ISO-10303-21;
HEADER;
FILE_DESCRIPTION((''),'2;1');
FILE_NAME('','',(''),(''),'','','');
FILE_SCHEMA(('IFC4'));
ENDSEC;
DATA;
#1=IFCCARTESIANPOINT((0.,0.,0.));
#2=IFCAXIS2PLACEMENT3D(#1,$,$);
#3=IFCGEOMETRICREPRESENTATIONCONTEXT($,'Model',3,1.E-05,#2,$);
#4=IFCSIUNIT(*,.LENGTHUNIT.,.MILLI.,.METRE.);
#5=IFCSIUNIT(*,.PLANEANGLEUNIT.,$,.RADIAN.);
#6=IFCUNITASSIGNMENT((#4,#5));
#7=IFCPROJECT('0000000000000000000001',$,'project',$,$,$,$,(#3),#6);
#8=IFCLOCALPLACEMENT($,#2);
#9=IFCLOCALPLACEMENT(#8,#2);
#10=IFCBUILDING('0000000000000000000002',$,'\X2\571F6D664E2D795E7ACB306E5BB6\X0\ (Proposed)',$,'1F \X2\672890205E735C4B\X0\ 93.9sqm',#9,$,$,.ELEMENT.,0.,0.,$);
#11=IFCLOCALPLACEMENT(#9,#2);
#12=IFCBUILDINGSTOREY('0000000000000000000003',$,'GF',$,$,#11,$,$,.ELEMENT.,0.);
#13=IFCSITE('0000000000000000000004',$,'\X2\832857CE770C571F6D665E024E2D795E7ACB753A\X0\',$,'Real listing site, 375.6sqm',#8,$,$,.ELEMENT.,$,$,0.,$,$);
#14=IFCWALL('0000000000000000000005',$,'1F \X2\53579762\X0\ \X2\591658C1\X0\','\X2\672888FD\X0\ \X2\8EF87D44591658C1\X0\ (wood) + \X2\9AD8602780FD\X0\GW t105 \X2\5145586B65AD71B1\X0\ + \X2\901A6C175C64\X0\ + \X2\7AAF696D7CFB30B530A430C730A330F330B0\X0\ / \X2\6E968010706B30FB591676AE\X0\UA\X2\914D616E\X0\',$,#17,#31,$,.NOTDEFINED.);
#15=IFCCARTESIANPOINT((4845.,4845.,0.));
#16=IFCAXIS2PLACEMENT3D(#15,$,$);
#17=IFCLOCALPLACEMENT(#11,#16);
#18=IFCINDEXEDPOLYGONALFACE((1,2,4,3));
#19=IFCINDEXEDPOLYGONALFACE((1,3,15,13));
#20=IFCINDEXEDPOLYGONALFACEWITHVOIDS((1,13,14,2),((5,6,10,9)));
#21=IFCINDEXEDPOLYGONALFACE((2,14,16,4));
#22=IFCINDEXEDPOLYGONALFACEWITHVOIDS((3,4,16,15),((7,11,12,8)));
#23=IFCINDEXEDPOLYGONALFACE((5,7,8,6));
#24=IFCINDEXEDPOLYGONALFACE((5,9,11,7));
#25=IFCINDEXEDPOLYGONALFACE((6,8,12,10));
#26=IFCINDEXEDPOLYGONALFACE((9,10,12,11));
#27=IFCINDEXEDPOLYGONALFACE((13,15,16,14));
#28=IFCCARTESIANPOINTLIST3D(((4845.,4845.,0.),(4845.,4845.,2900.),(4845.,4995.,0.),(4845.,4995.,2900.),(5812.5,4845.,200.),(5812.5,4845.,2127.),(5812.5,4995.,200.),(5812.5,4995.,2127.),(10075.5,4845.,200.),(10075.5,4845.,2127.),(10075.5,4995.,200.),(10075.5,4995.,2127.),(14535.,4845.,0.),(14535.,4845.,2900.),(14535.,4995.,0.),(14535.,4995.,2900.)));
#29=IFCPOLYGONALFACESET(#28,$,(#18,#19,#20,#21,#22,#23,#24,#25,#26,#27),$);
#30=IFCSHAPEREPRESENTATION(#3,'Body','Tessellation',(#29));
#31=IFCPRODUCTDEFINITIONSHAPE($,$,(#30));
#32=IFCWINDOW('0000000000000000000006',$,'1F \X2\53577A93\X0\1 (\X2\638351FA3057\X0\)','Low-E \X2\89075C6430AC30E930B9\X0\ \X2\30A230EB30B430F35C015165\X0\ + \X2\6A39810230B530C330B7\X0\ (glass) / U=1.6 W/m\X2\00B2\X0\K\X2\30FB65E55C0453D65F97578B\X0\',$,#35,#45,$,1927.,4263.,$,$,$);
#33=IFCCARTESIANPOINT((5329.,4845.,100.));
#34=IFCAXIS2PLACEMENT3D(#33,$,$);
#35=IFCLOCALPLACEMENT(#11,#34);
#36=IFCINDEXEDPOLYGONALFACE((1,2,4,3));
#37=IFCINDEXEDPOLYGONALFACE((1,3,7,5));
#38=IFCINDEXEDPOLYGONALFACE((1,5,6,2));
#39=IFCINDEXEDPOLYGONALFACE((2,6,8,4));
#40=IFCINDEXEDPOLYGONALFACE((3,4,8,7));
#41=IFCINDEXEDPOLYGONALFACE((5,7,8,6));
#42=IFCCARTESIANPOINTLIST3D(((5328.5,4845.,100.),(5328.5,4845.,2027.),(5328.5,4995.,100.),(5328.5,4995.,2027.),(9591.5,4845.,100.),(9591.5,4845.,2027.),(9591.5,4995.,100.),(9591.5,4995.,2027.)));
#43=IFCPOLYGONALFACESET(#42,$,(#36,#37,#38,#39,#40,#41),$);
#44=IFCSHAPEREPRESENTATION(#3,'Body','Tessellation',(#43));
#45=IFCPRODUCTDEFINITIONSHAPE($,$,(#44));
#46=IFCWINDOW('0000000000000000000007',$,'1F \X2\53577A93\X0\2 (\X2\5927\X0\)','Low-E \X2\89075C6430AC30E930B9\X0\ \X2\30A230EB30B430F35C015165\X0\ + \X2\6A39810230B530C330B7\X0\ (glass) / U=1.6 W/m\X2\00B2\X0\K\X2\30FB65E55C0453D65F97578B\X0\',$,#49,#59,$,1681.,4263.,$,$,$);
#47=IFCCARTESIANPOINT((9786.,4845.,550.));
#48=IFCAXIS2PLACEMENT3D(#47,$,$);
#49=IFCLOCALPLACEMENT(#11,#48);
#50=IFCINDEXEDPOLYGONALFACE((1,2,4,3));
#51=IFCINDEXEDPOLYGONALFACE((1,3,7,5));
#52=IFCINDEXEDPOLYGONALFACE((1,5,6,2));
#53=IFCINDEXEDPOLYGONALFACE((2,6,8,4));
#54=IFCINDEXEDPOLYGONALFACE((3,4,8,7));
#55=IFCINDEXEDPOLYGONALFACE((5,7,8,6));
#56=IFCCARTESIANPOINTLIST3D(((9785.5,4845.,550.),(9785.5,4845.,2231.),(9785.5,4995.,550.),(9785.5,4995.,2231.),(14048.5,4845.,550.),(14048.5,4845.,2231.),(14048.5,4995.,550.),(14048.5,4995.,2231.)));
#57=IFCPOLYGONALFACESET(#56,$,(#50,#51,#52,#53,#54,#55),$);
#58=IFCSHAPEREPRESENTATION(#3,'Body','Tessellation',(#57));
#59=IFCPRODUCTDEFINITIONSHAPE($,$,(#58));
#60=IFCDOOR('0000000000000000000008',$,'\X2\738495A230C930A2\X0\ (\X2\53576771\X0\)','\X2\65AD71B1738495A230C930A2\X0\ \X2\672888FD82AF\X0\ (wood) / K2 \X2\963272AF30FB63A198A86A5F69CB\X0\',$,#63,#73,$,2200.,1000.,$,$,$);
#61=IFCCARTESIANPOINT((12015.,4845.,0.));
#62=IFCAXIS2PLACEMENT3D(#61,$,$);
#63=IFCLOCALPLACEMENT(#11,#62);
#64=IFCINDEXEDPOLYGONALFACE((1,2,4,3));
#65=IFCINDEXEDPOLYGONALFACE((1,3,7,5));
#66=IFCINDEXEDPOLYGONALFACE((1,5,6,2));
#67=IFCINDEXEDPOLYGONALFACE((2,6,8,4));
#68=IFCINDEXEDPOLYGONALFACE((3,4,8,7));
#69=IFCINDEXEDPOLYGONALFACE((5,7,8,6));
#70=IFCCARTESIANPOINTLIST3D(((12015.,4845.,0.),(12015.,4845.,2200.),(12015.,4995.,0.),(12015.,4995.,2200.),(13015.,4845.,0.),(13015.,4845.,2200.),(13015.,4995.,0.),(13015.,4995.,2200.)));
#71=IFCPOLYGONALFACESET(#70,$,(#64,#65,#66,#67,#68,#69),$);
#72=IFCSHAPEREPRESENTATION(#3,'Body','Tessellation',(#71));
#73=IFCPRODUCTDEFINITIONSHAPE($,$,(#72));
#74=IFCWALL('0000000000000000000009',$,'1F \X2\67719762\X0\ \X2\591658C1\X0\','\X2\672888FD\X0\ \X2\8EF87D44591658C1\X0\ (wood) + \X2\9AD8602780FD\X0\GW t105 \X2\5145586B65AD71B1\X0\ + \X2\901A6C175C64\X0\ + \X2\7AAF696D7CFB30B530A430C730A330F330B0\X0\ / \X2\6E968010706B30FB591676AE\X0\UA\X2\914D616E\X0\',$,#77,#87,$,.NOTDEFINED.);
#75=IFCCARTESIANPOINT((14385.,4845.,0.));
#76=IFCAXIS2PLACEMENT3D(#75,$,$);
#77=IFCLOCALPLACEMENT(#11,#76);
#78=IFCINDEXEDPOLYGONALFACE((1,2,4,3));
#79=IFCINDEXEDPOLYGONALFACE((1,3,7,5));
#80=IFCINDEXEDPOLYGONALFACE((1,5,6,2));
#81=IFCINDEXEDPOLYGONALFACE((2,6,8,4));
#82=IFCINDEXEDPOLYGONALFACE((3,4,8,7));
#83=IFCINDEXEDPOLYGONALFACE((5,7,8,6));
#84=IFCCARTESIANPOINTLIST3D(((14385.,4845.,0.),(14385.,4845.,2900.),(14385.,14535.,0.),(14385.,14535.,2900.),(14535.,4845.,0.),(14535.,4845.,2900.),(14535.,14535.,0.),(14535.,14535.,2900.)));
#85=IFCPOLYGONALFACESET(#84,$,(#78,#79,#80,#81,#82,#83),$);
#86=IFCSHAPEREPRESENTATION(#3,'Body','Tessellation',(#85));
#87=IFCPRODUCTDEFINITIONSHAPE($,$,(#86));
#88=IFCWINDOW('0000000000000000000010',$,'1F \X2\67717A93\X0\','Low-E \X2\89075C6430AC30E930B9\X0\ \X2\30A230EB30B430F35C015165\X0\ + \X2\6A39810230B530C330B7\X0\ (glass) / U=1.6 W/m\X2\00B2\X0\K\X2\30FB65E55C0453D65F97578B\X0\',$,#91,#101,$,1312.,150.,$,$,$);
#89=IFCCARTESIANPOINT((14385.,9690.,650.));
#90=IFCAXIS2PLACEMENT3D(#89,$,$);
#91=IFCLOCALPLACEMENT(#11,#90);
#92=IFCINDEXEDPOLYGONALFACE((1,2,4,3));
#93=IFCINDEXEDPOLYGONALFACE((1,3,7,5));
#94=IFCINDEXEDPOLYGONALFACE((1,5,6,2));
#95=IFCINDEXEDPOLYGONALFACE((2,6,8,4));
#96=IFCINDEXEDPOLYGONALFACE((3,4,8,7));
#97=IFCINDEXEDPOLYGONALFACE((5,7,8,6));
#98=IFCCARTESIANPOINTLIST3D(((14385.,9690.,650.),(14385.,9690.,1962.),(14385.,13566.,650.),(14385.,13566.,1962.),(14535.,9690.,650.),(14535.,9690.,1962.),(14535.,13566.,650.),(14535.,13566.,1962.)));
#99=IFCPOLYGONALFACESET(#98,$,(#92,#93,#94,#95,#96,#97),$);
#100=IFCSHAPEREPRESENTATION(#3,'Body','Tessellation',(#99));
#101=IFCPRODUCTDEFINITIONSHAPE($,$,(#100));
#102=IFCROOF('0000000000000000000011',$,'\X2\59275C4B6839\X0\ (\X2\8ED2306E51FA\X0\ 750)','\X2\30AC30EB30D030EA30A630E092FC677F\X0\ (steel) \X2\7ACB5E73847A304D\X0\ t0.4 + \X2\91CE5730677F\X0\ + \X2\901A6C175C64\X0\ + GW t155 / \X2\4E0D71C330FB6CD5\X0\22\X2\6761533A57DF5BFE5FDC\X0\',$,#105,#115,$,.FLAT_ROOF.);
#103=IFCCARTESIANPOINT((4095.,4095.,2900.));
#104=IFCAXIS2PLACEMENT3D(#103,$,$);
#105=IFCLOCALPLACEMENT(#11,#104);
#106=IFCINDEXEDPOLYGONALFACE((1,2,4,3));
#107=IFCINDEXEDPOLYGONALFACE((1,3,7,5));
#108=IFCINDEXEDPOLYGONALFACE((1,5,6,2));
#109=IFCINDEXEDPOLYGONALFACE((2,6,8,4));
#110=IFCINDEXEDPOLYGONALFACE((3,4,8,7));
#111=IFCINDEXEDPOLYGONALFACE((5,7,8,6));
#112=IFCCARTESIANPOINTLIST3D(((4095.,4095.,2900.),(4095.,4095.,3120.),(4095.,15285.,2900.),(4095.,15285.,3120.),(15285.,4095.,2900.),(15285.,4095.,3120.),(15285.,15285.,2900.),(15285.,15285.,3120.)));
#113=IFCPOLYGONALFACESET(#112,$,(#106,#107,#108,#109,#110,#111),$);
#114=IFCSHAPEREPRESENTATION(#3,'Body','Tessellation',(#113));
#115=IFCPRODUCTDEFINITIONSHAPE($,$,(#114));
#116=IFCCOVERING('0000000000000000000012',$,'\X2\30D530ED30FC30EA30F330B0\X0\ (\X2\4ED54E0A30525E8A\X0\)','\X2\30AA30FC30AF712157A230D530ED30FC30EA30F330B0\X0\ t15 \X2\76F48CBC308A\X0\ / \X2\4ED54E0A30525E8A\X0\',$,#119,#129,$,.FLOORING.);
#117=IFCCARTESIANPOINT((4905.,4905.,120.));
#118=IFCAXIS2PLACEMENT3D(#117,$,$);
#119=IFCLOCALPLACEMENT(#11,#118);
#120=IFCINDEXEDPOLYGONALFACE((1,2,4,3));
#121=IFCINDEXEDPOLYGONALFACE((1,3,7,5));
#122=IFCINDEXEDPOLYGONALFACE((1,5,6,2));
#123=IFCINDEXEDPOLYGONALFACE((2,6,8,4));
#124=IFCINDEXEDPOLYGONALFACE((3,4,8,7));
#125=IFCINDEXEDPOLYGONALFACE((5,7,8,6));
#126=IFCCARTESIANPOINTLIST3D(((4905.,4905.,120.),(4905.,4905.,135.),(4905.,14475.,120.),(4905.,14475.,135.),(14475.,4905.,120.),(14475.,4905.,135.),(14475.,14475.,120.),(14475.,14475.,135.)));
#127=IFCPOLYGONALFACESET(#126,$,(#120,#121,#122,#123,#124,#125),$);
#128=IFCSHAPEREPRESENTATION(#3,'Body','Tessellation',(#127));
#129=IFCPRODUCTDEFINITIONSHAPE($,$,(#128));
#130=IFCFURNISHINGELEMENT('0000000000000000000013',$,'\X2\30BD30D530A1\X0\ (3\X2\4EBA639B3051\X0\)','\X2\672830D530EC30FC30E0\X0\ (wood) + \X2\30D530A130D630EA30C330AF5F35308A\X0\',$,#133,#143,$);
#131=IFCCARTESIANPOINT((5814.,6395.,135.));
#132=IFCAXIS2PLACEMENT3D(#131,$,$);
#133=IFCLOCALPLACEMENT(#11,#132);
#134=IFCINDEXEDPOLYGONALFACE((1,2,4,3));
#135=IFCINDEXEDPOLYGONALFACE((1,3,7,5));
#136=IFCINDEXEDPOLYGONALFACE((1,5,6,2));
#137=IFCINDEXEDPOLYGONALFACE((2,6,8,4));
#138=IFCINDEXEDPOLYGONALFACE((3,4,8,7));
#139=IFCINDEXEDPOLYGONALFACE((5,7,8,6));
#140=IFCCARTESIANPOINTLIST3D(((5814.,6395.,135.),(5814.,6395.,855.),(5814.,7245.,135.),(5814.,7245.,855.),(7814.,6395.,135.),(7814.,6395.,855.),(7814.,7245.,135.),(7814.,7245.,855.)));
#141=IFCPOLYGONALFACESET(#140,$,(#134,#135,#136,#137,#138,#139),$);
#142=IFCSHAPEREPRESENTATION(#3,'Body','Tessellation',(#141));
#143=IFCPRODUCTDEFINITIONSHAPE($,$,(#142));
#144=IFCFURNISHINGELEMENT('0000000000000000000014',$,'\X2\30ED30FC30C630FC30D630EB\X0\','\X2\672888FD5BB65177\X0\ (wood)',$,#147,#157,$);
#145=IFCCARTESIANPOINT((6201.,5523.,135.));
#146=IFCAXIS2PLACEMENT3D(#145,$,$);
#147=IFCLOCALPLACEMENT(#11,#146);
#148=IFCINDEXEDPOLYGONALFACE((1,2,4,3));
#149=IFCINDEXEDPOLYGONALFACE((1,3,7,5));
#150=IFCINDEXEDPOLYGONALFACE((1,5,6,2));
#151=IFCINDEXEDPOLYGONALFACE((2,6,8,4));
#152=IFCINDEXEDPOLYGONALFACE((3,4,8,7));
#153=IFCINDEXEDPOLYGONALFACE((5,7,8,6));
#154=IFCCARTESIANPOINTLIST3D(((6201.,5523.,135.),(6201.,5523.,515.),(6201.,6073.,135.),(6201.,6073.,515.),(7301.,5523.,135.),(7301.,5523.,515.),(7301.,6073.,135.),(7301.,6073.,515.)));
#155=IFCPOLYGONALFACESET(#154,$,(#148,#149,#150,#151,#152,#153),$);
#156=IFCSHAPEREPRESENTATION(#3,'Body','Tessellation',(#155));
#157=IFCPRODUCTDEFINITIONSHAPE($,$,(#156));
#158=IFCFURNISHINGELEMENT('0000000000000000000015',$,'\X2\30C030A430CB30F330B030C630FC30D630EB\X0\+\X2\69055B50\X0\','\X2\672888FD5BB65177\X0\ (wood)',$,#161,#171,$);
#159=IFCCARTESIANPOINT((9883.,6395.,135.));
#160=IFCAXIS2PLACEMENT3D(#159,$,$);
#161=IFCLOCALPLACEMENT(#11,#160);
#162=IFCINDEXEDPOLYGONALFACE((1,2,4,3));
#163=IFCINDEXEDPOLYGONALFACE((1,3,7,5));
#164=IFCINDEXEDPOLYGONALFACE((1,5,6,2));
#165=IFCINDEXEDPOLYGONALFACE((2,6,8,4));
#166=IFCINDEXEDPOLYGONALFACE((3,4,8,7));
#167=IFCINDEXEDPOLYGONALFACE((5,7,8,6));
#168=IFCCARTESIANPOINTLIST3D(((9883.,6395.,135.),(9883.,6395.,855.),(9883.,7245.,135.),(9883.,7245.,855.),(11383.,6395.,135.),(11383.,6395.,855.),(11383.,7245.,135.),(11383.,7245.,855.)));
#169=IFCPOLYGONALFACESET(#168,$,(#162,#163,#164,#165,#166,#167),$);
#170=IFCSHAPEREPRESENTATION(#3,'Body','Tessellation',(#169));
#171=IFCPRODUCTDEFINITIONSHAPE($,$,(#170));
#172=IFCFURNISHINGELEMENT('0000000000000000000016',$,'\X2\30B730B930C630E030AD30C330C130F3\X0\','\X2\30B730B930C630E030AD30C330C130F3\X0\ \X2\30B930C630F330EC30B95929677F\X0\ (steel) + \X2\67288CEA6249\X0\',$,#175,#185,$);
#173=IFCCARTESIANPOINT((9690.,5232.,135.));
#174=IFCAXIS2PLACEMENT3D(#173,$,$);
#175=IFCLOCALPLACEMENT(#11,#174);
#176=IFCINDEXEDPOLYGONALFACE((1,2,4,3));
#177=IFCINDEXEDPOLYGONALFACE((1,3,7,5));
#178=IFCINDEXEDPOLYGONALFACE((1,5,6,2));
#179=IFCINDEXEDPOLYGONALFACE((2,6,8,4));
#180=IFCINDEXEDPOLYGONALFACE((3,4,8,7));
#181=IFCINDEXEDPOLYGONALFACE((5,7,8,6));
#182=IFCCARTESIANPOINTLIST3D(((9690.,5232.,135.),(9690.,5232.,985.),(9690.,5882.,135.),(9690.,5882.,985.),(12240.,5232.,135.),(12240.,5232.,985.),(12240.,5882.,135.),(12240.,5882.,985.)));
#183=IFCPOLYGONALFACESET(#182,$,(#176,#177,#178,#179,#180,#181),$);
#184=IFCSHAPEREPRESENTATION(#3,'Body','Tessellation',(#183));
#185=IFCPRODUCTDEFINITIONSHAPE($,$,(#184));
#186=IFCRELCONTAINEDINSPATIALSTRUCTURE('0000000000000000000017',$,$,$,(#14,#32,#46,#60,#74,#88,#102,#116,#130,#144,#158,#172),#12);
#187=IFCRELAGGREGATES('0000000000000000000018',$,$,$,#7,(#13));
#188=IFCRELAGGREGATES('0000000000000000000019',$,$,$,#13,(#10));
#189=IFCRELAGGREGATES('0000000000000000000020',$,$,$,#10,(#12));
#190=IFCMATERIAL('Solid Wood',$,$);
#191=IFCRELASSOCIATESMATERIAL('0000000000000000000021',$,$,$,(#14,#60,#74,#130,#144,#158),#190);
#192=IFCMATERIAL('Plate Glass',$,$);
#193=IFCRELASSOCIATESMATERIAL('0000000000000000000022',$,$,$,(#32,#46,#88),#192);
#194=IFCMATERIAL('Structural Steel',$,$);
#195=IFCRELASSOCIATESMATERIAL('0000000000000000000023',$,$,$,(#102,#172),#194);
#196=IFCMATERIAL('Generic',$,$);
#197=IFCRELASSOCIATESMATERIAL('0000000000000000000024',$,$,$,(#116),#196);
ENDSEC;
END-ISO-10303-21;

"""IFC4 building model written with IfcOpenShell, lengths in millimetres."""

from ifc_helpers import new_model, si_unit, frame, frame_2d, origin, place, context, project, spatial, rectangle, extrude, material, element, fill, save


model = new_model("IFC4")

# Units and contexts
model_context = context("Model", 3, precision=1e-05, world=origin())
ifc_project = project(units=[si_unit("LENGTHUNIT", "METRE", prefix="MILLI"), si_unit("PLANEANGLEUNIT", "RADIAN")], contexts=[model_context])

# Site, building, storey
site_placement = place(None, origin())
site = spatial("IfcSite", under=ifc_project, at=site_placement, Name="茨城県土浦市中神立町", ObjectType="Real listing site, 375.6sqm", CompositionType="ELEMENT", RefElevation=0.0)
building_placement = place(site_placement, origin())
building = spatial("IfcBuilding", under=site, at=building_placement, Name="土浦中神立の家 (Proposed)", ObjectType="1F 木造平屋 93.9sqm", CompositionType="ELEMENT", ElevationOfRefHeight=0.0, ElevationOfTerrain=0.0)
storey_placement = place(building_placement, origin())
storey = spatial("IfcBuildingStorey", under=building, at=storey_placement, Name="GF", CompositionType="ELEMENT", Elevation=0.0)

# Shared definitions
ifc_material_1 = material(Name="Solid Wood")

# Wall, openings, windows, door
wall_1_placement = place(storey_placement, frame((4845.0, 4845.0, 0.0)))
wall_1 = element("IfcWall", 1, at=wall_1_placement, inside=storey, material=ifc_material_1, Name="1F 南面 外壁", Description="木製 軸組外壁 (wood) + 高性能GW t105 充填断熱 + 通気層 + 窯業系サイディング / 準耐火・外皮UA配慮", PredefinedType="NOTDEFINED", context=model_context, shape_type="SweptSolid", body=[
    extrude(rectangle(XDim=9690.0, YDim=150.0, at=frame_2d((4845.0, 75.0))), frame((4845.0, 4845.0, 0.0)), (0.0, 0.0, 1.0), 2900.0),
])
opening_1_placement = place(storey_placement, frame((5329.0, 4845.0, 100.0)))
opening_1 = element("IfcOpeningElement", 2, at=opening_1_placement, cuts=wall_1, PredefinedType="NOTDEFINED", context=model_context, shape_type="SweptSolid", body=[
    extrude(rectangle(XDim=4263.0, YDim=150.0, at=frame_2d((2131.0, 75.0))), frame((5329.0, 4845.0, 100.0)), (0.0, 0.0, 1.0), 1927.0),
])
opening_2_placement = place(storey_placement, frame((9786.0, 4845.0, 550.0)))
opening_2 = element("IfcOpeningElement", 3, at=opening_2_placement, cuts=wall_1, PredefinedType="NOTDEFINED", context=model_context, shape_type="SweptSolid", body=[
    extrude(rectangle(XDim=4263.0, YDim=150.0, at=frame_2d((2131.0, 75.0))), frame((9786.0, 4845.0, 550.0)), (0.0, 0.0, 1.0), 1681.0),
])
opening_3_placement = place(storey_placement, frame((12015.0, 4845.0, 0.0)))
opening_3 = element("IfcOpeningElement", 4, at=opening_3_placement, cuts=wall_1, PredefinedType="NOTDEFINED", context=model_context, shape_type="SweptSolid", body=[
    extrude(rectangle(XDim=1000.0, YDim=150.0, at=frame_2d((500.0, 75.0))), frame((12015.0, 4845.0, 0.0)), (0.0, 0.0, 1.0), 2200.0),
])
ifc_material_2 = material(Name="Plate Glass")
window_1_placement = place(storey_placement, frame((5329.0, 4845.0, 100.0)))
window_1 = element("IfcWindow", 5, at=window_1_placement, inside=storey, material=ifc_material_2, Name="1F 南窓1 (掃出し)", Description="Low-E 複層ガラス アルゴン封入 + 樹脂サッシ (glass) / U=1.6 W/m²K・日射取得型", OverallHeight=1927.0, OverallWidth=4263.0, context=model_context, shape_type="SweptSolid", body=[
    extrude(rectangle(XDim=4263.0, YDim=150.0, at=frame_2d((2131.0, 75.0))), frame((5329.0, 4845.0, 100.0)), (0.0, 0.0, 1.0), 1927.0),
])
fill(opening_1, window_1)
window_2_placement = place(storey_placement, frame((9786.0, 4845.0, 550.0)))
window_2 = element("IfcWindow", 6, at=window_2_placement, inside=storey, material=ifc_material_2, Name="1F 南窓2 (大)", Description="Low-E 複層ガラス アルゴン封入 + 樹脂サッシ (glass) / U=1.6 W/m²K・日射取得型", OverallHeight=1681.0, OverallWidth=4263.0, context=model_context, shape_type="SweptSolid", body=[
    extrude(rectangle(XDim=4263.0, YDim=150.0, at=frame_2d((2131.0, 75.0))), frame((9786.0, 4845.0, 550.0)), (0.0, 0.0, 1.0), 1681.0),
])
fill(opening_2, window_2)
door_placement = place(storey_placement, frame((12015.0, 4845.0, 0.0)))
door = element("IfcDoor", 7, at=door_placement, inside=storey, material=ifc_material_1, Name="玄関ドア (南東)", Description="断熱玄関ドア 木製芯 (wood) / K2 防犯・採風機構", OverallHeight=2200.0, OverallWidth=1000.0, context=model_context, shape_type="SweptSolid", body=[
    extrude(rectangle(XDim=1000.0, YDim=150.0, at=frame_2d((500.0, 75.0))), frame((12015.0, 4845.0, 0.0)), (0.0, 0.0, 1.0), 2200.0),
])
fill(opening_3, door)

# Wall, opening, window
wall_2_placement = place(storey_placement, frame((14385.0, 4845.0, 0.0)))
wall_2 = element("IfcWall", 8, at=wall_2_placement, inside=storey, material=ifc_material_1, Name="1F 東面 外壁", Description="木製 軸組外壁 (wood) + 高性能GW t105 充填断熱 + 通気層 + 窯業系サイディング / 準耐火・外皮UA配慮", PredefinedType="NOTDEFINED", context=model_context, shape_type="SweptSolid", body=[
    extrude(rectangle(XDim=150.0, YDim=9690.0, at=frame_2d((75.0, 4845.0))), frame((14385.0, 4845.0, 0.0)), (0.0, 0.0, 1.0), 2900.0),
])
opening_4_placement = place(storey_placement, frame((14385.0, 9690.0, 650.0)))
opening_4 = element("IfcOpeningElement", 9, at=opening_4_placement, cuts=wall_2, PredefinedType="NOTDEFINED", context=model_context, shape_type="SweptSolid", body=[
    extrude(rectangle(XDim=150.0, YDim=3876.0, at=frame_2d((75.0, 1938.0))), frame((14385.0, 9690.0, 650.0)), (0.0, 0.0, 1.0), 1312.0),
])
window_3_placement = place(storey_placement, frame((14385.0, 9690.0, 650.0)))
window_3 = element("IfcWindow", 10, at=window_3_placement, inside=storey, material=ifc_material_2, Name="1F 東窓", Description="Low-E 複層ガラス アルゴン封入 + 樹脂サッシ (glass) / U=1.6 W/m²K・日射取得型", OverallHeight=1312.0, OverallWidth=150.0, context=model_context, shape_type="SweptSolid", body=[
    extrude(rectangle(XDim=150.0, YDim=3876.0, at=frame_2d((75.0, 1938.0))), frame((14385.0, 9690.0, 650.0)), (0.0, 0.0, 1.0), 1312.0),
])
fill(opening_4, window_3)

# Roof
ifc_material_3 = material(Name="Structural Steel")
roof_placement = place(storey_placement, frame((4095.0, 4095.0, 2900.0)))
element("IfcRoof", 11, at=roof_placement, inside=storey, material=ifc_material_3, Name="大屋根 (軒の出 750)", Description="ガルバリウム鋼板 (steel) 立平葺き t0.4 + 野地板 + 通気層 + GW t155 / 不燃・法22条区域対応", PredefinedType="FLAT_ROOF", context=model_context, shape_type="SweptSolid", body=[
    extrude(rectangle(XDim=11190.0, YDim=11190.0, at=frame_2d((5595.0, 5595.0))), frame((4095.0, 4095.0, 2900.0)), (0.0, 0.0, 1.0), 220.0),
])

# Covering
ifc_material_4 = material(Name="Generic")
covering_placement = place(storey_placement, frame((4905.0, 4905.0, 120.0)))
element("IfcCovering", 12, at=covering_placement, inside=storey, material=ifc_material_4, Name="フローリング (仕上げ床)", Description="オーク無垢フローリング t15 直貼り / 仕上げ床", PredefinedType="FLOORING", context=model_context, shape_type="SweptSolid", body=[
    extrude(rectangle(XDim=9570.0, YDim=9570.0, at=frame_2d((4785.0, 4785.0))), frame((4905.0, 4905.0, 120.0)), (0.0, 0.0, 1.0), 15.0),
])

# Furnishing elements
furnishing_1_placement = place(storey_placement, frame((5814.0, 6395.0, 135.0)))
element("IfcFurnishingElement", 13, at=furnishing_1_placement, inside=storey, material=ifc_material_1, Name="ソファ (3人掛け)", Description="木フレーム (wood) + ファブリック張り", context=model_context, shape_type="SweptSolid", body=[
    extrude(rectangle(XDim=2000.0, YDim=850.0, at=frame_2d((1000.0, 425.0))), frame((5814.0, 6395.0, 135.0)), (0.0, 0.0, 1.0), 720.0),
])
furnishing_2_placement = place(storey_placement, frame((6201.0, 5523.0, 135.0)))
element("IfcFurnishingElement", 14, at=furnishing_2_placement, inside=storey, material=ifc_material_1, Name="ローテーブル", Description="木製家具 (wood)", context=model_context, shape_type="SweptSolid", body=[
    extrude(rectangle(XDim=1100.0, YDim=550.0, at=frame_2d((550.0, 275.0))), frame((6201.0, 5523.0, 135.0)), (0.0, 0.0, 1.0), 380.0),
])
furnishing_3_placement = place(storey_placement, frame((9883.0, 6395.0, 135.0)))
element("IfcFurnishingElement", 15, at=furnishing_3_placement, inside=storey, material=ifc_material_1, Name="ダイニングテーブル+椅子", Description="木製家具 (wood)", context=model_context, shape_type="SweptSolid", body=[
    extrude(rectangle(XDim=1500.0, YDim=850.0, at=frame_2d((750.0, 425.0))), frame((9883.0, 6395.0, 135.0)), (0.0, 0.0, 1.0), 720.0),
])
furnishing_4_placement = place(storey_placement, frame((9690.0, 5232.0, 135.0)))
element("IfcFurnishingElement", 16, at=furnishing_4_placement, inside=storey, material=ifc_material_3, Name="システムキッチン", Description="システムキッチン ステンレス天板 (steel) + 木質扉", context=model_context, shape_type="SweptSolid", body=[
    extrude(rectangle(XDim=2550.0, YDim=650.0, at=frame_2d((1275.0, 325.0))), frame((9690.0, 5232.0, 135.0)), (0.0, 0.0, 1.0), 850.0),
])

save(model, "model.ifc")
